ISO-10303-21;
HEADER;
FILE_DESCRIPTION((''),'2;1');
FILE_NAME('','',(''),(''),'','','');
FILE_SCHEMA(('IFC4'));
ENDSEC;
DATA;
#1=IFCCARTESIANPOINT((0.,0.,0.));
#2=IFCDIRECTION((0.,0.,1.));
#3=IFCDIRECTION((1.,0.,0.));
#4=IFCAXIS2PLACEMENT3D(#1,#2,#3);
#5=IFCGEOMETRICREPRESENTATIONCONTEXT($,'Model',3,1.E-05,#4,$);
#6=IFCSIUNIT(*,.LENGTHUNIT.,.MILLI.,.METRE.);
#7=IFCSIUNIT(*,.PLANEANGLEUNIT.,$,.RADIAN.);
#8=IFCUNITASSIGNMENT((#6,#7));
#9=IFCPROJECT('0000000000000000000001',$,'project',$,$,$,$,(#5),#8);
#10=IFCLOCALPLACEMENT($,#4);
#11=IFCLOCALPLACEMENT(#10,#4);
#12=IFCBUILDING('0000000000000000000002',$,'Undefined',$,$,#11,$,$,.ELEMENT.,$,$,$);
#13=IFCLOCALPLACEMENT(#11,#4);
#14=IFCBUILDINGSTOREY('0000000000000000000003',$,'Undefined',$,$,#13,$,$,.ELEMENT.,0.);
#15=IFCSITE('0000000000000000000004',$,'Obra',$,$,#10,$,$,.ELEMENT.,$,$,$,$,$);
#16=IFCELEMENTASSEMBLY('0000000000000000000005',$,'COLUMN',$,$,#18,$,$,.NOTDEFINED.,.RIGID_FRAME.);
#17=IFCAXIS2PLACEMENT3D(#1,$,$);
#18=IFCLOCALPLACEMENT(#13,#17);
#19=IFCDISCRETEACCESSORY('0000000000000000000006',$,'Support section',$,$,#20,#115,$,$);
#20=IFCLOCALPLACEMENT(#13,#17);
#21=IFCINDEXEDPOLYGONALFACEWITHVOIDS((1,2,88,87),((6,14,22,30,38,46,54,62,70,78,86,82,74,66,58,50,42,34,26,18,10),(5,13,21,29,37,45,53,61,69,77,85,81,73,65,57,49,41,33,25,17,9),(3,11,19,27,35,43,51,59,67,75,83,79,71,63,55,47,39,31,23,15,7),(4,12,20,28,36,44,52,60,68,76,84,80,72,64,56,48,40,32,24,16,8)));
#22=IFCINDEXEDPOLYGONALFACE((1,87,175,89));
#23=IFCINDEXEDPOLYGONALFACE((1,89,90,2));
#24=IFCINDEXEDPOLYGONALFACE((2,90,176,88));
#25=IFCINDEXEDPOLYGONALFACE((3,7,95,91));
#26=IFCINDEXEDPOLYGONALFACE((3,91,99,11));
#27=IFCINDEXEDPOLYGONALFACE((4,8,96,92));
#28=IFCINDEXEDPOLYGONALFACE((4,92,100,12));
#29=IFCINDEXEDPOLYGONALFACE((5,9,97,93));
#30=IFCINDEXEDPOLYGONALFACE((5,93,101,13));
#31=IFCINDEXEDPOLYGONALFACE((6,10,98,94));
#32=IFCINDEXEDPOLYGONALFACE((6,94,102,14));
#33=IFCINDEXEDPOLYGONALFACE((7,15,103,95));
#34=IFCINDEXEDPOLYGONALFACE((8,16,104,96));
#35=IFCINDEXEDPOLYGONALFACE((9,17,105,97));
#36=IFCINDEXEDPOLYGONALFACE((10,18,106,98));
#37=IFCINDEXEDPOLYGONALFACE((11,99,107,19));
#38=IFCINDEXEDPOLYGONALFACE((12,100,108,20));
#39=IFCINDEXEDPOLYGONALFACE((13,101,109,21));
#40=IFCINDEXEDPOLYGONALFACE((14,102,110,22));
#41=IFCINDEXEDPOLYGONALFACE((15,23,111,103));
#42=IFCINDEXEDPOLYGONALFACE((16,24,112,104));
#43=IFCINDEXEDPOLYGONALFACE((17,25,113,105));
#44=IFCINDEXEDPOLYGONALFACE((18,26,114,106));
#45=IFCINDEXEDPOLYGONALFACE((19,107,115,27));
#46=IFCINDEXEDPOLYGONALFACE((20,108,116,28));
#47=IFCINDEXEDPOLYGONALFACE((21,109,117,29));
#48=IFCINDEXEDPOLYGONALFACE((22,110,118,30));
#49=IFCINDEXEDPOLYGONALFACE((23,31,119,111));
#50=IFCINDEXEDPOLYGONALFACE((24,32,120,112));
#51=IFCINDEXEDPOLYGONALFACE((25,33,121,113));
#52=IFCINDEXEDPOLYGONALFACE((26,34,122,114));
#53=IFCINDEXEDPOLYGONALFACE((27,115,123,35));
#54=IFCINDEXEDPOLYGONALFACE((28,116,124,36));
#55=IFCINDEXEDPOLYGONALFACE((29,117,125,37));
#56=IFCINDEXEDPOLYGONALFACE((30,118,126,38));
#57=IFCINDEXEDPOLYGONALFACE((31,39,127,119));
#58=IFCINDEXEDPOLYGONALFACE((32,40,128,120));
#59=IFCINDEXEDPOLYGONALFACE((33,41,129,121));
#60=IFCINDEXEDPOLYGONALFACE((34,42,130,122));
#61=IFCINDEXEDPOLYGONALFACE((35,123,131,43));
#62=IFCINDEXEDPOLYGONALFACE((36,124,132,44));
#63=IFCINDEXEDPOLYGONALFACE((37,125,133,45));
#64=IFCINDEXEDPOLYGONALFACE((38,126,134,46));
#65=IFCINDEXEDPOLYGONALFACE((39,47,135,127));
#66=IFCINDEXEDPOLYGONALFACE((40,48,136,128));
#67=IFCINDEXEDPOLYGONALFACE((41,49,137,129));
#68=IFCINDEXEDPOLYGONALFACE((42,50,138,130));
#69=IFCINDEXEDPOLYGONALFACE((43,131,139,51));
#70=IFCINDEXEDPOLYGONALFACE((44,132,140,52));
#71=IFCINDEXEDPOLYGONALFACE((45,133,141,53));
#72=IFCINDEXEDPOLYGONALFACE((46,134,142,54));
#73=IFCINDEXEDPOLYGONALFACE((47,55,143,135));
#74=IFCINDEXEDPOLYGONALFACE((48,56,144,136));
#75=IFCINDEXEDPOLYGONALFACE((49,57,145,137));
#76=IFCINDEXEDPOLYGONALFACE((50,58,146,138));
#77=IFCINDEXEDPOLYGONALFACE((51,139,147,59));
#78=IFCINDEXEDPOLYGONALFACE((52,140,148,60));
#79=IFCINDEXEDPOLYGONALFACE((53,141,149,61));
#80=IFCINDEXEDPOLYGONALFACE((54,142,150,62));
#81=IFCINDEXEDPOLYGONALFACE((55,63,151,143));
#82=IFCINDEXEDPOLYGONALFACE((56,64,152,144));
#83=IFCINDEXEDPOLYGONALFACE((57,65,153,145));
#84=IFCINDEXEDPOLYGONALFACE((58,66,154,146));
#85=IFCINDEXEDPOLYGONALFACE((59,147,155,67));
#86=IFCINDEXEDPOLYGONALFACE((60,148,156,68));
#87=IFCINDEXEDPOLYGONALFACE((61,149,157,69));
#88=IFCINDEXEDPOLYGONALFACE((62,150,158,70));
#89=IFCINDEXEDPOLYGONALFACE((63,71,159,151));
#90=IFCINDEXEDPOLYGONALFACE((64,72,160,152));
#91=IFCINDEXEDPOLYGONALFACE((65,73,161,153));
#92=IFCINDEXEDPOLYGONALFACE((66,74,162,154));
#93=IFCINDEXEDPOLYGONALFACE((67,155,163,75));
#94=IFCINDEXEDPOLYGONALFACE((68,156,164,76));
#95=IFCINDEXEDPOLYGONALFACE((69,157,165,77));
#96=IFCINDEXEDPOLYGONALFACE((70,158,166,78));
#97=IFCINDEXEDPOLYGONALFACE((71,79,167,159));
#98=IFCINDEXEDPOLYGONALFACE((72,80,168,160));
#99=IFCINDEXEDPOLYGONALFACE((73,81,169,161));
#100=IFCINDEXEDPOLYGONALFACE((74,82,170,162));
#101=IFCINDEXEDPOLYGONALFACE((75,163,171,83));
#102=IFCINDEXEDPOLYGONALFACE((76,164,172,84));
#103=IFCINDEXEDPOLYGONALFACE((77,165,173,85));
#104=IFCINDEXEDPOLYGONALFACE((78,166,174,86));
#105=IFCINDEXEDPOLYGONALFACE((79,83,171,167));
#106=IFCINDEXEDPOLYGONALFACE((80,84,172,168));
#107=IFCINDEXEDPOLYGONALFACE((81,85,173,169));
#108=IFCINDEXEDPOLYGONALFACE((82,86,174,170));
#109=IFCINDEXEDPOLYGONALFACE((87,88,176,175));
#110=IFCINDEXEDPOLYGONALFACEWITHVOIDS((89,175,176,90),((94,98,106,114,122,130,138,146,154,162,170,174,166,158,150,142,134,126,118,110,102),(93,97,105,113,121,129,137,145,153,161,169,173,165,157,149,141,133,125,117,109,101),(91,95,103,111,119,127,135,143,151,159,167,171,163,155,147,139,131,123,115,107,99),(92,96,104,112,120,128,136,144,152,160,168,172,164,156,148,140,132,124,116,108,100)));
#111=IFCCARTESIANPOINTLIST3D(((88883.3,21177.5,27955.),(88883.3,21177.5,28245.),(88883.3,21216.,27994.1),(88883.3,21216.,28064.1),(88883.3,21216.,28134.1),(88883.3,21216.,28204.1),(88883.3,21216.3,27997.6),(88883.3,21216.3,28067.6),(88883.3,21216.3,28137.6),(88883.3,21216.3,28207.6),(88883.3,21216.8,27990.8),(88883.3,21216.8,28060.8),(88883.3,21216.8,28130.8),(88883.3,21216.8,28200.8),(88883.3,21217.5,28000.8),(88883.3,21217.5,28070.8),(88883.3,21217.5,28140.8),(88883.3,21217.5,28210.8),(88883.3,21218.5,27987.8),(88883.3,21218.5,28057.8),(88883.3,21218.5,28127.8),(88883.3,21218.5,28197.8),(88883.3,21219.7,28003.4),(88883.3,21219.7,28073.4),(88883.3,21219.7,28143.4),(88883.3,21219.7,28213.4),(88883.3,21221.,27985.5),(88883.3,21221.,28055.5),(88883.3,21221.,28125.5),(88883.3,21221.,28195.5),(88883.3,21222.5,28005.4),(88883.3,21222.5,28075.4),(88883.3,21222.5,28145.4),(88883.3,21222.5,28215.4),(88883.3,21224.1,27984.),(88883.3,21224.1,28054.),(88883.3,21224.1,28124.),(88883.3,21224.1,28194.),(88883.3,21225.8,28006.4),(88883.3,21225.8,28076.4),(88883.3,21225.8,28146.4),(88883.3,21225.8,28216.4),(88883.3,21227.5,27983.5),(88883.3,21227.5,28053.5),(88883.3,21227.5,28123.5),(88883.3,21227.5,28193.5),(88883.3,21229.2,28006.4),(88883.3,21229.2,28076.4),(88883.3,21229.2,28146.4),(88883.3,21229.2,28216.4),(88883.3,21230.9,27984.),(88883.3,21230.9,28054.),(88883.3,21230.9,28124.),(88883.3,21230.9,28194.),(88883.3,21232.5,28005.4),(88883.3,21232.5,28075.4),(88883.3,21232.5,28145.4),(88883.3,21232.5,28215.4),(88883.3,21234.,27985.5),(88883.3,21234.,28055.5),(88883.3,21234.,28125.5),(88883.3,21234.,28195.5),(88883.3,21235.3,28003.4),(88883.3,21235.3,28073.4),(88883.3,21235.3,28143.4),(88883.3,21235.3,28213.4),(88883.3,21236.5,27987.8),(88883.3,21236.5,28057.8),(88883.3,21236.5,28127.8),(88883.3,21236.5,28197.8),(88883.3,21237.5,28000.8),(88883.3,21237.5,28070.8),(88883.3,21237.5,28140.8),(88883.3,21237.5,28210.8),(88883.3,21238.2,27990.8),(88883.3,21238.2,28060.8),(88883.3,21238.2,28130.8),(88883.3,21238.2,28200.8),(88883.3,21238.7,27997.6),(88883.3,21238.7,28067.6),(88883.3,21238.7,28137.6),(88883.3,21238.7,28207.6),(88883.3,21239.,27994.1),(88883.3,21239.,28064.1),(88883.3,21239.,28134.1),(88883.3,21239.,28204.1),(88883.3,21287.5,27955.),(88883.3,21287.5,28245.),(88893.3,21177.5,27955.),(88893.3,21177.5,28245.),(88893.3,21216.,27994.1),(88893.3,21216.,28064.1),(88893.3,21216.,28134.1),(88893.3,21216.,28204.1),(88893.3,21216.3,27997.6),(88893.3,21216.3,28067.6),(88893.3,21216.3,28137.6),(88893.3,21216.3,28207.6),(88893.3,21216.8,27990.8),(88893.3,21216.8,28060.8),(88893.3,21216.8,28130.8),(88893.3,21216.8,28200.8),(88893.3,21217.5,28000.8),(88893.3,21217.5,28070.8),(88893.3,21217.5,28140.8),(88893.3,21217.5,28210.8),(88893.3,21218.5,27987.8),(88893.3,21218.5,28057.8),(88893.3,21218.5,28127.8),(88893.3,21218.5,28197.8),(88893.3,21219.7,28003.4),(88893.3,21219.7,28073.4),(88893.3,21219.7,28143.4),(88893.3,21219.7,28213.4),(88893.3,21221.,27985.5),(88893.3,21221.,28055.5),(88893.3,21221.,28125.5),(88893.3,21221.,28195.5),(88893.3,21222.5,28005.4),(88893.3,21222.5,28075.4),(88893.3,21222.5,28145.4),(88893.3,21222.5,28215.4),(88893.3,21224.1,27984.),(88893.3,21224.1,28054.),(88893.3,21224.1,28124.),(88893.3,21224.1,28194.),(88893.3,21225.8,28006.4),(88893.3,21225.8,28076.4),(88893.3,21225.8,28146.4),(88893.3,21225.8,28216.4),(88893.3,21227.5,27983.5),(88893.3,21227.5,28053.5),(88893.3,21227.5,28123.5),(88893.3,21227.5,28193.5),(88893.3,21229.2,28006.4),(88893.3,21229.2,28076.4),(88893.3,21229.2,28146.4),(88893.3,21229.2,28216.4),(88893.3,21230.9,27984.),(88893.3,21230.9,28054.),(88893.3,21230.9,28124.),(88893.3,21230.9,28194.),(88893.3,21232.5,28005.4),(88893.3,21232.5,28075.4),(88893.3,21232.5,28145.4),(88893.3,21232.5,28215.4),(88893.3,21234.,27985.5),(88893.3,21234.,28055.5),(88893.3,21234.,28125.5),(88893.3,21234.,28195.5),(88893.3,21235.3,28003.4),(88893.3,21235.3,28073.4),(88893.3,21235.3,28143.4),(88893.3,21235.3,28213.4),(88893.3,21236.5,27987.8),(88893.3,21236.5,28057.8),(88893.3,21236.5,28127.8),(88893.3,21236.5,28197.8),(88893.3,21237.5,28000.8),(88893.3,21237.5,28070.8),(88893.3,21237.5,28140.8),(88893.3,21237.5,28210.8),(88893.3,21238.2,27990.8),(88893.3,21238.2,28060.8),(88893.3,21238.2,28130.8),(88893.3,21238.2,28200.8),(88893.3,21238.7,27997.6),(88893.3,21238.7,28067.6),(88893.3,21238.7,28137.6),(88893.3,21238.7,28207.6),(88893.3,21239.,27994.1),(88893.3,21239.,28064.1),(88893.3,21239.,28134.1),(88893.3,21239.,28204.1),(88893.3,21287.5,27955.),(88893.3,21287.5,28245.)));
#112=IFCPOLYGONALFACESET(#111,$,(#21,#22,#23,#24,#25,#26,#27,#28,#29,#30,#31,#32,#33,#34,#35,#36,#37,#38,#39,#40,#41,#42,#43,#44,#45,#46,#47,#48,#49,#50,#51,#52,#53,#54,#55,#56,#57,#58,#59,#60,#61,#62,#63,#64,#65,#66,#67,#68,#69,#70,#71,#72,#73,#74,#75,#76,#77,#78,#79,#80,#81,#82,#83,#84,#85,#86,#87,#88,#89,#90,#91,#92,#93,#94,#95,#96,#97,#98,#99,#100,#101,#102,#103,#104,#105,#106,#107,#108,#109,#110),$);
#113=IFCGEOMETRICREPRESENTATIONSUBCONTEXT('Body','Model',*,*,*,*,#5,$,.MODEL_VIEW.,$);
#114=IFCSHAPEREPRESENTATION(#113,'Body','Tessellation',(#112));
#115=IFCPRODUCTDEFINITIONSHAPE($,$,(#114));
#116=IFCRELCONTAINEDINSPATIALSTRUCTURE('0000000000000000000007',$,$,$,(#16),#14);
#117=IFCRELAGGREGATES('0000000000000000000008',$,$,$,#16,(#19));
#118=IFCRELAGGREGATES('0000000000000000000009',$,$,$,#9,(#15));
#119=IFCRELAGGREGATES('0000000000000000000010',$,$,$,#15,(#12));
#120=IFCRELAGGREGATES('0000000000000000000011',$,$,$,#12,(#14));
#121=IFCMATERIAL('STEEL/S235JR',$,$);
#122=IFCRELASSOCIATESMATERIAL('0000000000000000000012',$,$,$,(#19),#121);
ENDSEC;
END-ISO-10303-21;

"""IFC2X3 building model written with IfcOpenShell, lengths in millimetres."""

from ifc_helpers import new_model, si_unit, frame, origin_with_axes, origin_2d_with_axis, place, context, subcontext, project, spatial, rectangle, circle, extrude, source, transform, mapped, material, element, aggregate, save


model = new_model("IFC2X3")

# Units and contexts
model_context = context("Model", 3, precision=1e-05, world=origin_with_axes())
body_context = subcontext(model_context, "Body", "Model", "MODEL_VIEW")
ifc_project = project(units=[si_unit("LENGTHUNIT", "METRE", prefix="MILLI"), si_unit("PLANEANGLEUNIT", "RADIAN")], contexts=[model_context])

# Site, building, storey
site_placement = place(None, origin_with_axes())
site = spatial("IfcSite", under=ifc_project, at=site_placement, Name="Obra", CompositionType="ELEMENT")
building_placement = place(site_placement, origin_with_axes())
building = spatial("IfcBuilding", under=site, at=building_placement, Name="Undefined", CompositionType="ELEMENT")
storey_placement = place(building_placement, origin_with_axes())
storey = spatial("IfcBuildingStorey", under=building, at=storey_placement, Name="Undefined", CompositionType="ELEMENT", Elevation=0.0)

# Element assembly
assembly_1_placement = place(storey_placement, origin_with_axes())
assembly_1 = element("IfcElementAssembly", 1, at=assembly_1_placement, inside=storey, Name="COLUMN", AssemblyPlace="NOTDEFINED", PredefinedType="RIGID_FRAME")
ifc_material = material(Name="STEEL/S235JR")

# Discrete accessory, opening
shared_shape_1 = source(origin_with_axes(), body_context, "Body", "SweptSolid", [
    extrude(circle(Radius=11.5, at=origin_2d_with_axis()), frame((0.0, -14.4, 0.0), z_axis=(0.0, 1.0, 0.0), x_axis=(1.0, 0.0, 0.0)), (0.0, 0.0, 1.0), 10.2),
])
discrete_accessory_1_placement = place(assembly_1_placement, frame((88888.3, 21232.5, 27955.0), z_axis=(0.0, 0.0, 1.0), x_axis=(0.0, 1.0, 0.0)))
discrete_accessory_1 = element("IfcDiscreteAccessory", 2, at=discrete_accessory_1_placement, material=ifc_material, Name="Support section", context=body_context, shape_type="SweptSolid", body=[
    extrude(rectangle(XDim=10.0, YDim=110.0, at=origin_2d_with_axis()), frame((0.0, 0.0, 290.0), z_axis=(0.0, 0.0, -1.0), x_axis=(0.0, 1.0, 0.0)), (0.0, 0.0, 1.0), 290.0),
])
opening_1_placement = place(assembly_1_placement, frame((88897.6, 21277.5, 28300.0), z_axis=(0.0, -1.0, 0.0), x_axis=(0.0, 0.0, -1.0)))
element("IfcOpeningElement", 3, at=opening_1_placement, cuts=discrete_accessory_1, ObjectType="Opening", context=body_context, shape_type="MappedRepresentation", body=[
    mapped(shared_shape_1, transform((95.0, 0.0, 50.0))),
    mapped(shared_shape_1, transform((165.0, 0.0, 50.0))),
    mapped(shared_shape_1, transform((235.0, 0.0, 50.0))),
    mapped(shared_shape_1, transform((305.0, 0.0, 50.0))),
])
aggregate(assembly_1, [discrete_accessory_1])

save(model, "model.ifc")
